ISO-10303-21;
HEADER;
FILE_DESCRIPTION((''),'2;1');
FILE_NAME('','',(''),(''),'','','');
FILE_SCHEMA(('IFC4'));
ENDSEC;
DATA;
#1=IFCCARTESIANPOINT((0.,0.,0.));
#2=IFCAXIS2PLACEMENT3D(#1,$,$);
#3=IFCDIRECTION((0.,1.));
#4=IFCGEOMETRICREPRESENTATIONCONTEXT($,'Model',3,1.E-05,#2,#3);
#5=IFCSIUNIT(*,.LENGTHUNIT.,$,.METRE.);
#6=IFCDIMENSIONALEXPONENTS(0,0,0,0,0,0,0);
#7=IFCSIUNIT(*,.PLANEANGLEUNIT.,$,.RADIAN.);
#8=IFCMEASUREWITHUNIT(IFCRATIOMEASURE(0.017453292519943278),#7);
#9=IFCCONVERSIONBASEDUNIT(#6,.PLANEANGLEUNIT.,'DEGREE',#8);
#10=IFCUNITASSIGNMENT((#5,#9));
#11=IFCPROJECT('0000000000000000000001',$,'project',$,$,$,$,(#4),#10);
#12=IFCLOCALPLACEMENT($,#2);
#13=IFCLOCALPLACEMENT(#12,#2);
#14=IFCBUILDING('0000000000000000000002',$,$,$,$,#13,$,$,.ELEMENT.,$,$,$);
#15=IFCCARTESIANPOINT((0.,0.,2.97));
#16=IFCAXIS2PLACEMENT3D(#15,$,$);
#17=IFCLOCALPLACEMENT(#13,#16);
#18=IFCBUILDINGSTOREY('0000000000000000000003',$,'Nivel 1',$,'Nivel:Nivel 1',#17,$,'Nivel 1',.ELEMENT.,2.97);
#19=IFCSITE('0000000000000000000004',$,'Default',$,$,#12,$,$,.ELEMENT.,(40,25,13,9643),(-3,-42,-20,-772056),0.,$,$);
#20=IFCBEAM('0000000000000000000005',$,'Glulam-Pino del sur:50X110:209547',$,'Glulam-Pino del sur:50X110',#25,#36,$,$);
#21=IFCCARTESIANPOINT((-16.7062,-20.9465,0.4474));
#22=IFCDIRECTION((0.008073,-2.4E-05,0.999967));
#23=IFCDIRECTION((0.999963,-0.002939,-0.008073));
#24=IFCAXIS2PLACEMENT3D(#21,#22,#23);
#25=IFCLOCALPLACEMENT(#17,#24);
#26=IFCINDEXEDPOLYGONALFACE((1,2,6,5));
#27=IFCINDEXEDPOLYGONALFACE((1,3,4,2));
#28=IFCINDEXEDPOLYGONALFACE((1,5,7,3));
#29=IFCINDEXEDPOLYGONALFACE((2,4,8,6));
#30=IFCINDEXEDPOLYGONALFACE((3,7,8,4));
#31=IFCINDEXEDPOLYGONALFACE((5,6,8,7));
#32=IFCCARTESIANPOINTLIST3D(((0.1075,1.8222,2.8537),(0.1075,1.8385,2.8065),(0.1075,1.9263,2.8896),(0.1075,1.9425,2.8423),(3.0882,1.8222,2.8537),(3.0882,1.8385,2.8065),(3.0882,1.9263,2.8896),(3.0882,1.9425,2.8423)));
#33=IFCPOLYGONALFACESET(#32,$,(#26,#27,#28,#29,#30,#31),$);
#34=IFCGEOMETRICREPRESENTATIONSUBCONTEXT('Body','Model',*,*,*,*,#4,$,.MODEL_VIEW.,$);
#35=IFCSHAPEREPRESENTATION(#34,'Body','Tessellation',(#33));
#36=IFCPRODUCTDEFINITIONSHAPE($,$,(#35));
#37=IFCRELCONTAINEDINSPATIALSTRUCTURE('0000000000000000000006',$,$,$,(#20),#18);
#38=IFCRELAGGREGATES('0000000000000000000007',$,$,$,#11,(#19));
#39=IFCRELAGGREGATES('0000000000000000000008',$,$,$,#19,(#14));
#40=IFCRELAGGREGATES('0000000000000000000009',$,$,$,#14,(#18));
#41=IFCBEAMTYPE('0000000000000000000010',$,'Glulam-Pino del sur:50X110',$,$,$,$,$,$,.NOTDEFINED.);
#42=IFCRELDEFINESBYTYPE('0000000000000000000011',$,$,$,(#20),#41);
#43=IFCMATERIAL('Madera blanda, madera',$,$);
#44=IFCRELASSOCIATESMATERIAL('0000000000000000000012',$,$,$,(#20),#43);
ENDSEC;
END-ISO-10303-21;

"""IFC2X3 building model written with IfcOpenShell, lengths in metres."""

from ifc_helpers import new_model, entity, si_unit, converted_unit, direction, frame, frame_2d, origin, place, context, subcontext, project, spatial, rectangle, extrude, material, type_object, element, save


model = new_model("IFC2X3")

# Units and contexts
model_context = context("Model", 3, precision=1e-05, world=origin(), true_north=direction((0.0, 1.0)))
body_context = subcontext(model_context, "Body", "Model", "MODEL_VIEW")
ifc_project = project(units=[si_unit("LENGTHUNIT", "METRE"), converted_unit("PLANEANGLEUNIT", "DEGREE", entity("IfcRatioMeasure", 0.017453292519943278), si_unit("PLANEANGLEUNIT", "RADIAN"), dimensions=[0, 0, 0, 0, 0, 0, 0])], contexts=[model_context])

# Site, building, storey
site_placement = place(None, origin())
site = spatial("IfcSite", under=ifc_project, at=site_placement, Name="Default", CompositionType="ELEMENT", RefLatitude=(40, 25, 13, 9643), RefLongitude=(-3, -42, -20, -772056), RefElevation=0.0)
building_placement = place(site_placement, origin())
building = spatial("IfcBuilding", under=site, at=building_placement, CompositionType="ELEMENT")
storey_placement = place(building_placement, frame((0.0, 0.0, 2.97)))
storey = spatial("IfcBuildingStorey", under=building, at=storey_placement, Name="Nivel 1", ObjectType="Nivel:Nivel 1", LongName="Nivel 1", CompositionType="ELEMENT", Elevation=2.97)

# Beam
ifc_material = material(Name="Madera blanda, madera")
beam_type = type_object("IfcBeamType", Name="Glulam-Pino del sur:50X110", PredefinedType="NOTDEFINED")
beam_placement = place(storey_placement, frame((-16.7062, -20.9465, 0.4474), z_axis=(0.008073, -0.000024, 0.999967), x_axis=(0.999963, -0.002939, -0.008073)))
element("IfcBeam", 1, at=beam_placement, inside=storey, type_object=beam_type, material=ifc_material, Name="Glulam-Pino del sur:50X110:209547", ObjectType="Glulam-Pino del sur:50X110", context=body_context, shape_type="SweptSolid", body=[
    extrude(rectangle(XDim=0.05, YDim=0.11, at=frame_2d((0.0, 0.0), x_axis=(0.0, 1.0))), frame((0.1075, 1.8824, 2.848), z_axis=(1.0, 0.0, 0.0), x_axis=(0.0, -0.945519, -0.325568)), (0.0, 0.0, 1.0), 2.9807),
])

save(model, "model.ifc")
